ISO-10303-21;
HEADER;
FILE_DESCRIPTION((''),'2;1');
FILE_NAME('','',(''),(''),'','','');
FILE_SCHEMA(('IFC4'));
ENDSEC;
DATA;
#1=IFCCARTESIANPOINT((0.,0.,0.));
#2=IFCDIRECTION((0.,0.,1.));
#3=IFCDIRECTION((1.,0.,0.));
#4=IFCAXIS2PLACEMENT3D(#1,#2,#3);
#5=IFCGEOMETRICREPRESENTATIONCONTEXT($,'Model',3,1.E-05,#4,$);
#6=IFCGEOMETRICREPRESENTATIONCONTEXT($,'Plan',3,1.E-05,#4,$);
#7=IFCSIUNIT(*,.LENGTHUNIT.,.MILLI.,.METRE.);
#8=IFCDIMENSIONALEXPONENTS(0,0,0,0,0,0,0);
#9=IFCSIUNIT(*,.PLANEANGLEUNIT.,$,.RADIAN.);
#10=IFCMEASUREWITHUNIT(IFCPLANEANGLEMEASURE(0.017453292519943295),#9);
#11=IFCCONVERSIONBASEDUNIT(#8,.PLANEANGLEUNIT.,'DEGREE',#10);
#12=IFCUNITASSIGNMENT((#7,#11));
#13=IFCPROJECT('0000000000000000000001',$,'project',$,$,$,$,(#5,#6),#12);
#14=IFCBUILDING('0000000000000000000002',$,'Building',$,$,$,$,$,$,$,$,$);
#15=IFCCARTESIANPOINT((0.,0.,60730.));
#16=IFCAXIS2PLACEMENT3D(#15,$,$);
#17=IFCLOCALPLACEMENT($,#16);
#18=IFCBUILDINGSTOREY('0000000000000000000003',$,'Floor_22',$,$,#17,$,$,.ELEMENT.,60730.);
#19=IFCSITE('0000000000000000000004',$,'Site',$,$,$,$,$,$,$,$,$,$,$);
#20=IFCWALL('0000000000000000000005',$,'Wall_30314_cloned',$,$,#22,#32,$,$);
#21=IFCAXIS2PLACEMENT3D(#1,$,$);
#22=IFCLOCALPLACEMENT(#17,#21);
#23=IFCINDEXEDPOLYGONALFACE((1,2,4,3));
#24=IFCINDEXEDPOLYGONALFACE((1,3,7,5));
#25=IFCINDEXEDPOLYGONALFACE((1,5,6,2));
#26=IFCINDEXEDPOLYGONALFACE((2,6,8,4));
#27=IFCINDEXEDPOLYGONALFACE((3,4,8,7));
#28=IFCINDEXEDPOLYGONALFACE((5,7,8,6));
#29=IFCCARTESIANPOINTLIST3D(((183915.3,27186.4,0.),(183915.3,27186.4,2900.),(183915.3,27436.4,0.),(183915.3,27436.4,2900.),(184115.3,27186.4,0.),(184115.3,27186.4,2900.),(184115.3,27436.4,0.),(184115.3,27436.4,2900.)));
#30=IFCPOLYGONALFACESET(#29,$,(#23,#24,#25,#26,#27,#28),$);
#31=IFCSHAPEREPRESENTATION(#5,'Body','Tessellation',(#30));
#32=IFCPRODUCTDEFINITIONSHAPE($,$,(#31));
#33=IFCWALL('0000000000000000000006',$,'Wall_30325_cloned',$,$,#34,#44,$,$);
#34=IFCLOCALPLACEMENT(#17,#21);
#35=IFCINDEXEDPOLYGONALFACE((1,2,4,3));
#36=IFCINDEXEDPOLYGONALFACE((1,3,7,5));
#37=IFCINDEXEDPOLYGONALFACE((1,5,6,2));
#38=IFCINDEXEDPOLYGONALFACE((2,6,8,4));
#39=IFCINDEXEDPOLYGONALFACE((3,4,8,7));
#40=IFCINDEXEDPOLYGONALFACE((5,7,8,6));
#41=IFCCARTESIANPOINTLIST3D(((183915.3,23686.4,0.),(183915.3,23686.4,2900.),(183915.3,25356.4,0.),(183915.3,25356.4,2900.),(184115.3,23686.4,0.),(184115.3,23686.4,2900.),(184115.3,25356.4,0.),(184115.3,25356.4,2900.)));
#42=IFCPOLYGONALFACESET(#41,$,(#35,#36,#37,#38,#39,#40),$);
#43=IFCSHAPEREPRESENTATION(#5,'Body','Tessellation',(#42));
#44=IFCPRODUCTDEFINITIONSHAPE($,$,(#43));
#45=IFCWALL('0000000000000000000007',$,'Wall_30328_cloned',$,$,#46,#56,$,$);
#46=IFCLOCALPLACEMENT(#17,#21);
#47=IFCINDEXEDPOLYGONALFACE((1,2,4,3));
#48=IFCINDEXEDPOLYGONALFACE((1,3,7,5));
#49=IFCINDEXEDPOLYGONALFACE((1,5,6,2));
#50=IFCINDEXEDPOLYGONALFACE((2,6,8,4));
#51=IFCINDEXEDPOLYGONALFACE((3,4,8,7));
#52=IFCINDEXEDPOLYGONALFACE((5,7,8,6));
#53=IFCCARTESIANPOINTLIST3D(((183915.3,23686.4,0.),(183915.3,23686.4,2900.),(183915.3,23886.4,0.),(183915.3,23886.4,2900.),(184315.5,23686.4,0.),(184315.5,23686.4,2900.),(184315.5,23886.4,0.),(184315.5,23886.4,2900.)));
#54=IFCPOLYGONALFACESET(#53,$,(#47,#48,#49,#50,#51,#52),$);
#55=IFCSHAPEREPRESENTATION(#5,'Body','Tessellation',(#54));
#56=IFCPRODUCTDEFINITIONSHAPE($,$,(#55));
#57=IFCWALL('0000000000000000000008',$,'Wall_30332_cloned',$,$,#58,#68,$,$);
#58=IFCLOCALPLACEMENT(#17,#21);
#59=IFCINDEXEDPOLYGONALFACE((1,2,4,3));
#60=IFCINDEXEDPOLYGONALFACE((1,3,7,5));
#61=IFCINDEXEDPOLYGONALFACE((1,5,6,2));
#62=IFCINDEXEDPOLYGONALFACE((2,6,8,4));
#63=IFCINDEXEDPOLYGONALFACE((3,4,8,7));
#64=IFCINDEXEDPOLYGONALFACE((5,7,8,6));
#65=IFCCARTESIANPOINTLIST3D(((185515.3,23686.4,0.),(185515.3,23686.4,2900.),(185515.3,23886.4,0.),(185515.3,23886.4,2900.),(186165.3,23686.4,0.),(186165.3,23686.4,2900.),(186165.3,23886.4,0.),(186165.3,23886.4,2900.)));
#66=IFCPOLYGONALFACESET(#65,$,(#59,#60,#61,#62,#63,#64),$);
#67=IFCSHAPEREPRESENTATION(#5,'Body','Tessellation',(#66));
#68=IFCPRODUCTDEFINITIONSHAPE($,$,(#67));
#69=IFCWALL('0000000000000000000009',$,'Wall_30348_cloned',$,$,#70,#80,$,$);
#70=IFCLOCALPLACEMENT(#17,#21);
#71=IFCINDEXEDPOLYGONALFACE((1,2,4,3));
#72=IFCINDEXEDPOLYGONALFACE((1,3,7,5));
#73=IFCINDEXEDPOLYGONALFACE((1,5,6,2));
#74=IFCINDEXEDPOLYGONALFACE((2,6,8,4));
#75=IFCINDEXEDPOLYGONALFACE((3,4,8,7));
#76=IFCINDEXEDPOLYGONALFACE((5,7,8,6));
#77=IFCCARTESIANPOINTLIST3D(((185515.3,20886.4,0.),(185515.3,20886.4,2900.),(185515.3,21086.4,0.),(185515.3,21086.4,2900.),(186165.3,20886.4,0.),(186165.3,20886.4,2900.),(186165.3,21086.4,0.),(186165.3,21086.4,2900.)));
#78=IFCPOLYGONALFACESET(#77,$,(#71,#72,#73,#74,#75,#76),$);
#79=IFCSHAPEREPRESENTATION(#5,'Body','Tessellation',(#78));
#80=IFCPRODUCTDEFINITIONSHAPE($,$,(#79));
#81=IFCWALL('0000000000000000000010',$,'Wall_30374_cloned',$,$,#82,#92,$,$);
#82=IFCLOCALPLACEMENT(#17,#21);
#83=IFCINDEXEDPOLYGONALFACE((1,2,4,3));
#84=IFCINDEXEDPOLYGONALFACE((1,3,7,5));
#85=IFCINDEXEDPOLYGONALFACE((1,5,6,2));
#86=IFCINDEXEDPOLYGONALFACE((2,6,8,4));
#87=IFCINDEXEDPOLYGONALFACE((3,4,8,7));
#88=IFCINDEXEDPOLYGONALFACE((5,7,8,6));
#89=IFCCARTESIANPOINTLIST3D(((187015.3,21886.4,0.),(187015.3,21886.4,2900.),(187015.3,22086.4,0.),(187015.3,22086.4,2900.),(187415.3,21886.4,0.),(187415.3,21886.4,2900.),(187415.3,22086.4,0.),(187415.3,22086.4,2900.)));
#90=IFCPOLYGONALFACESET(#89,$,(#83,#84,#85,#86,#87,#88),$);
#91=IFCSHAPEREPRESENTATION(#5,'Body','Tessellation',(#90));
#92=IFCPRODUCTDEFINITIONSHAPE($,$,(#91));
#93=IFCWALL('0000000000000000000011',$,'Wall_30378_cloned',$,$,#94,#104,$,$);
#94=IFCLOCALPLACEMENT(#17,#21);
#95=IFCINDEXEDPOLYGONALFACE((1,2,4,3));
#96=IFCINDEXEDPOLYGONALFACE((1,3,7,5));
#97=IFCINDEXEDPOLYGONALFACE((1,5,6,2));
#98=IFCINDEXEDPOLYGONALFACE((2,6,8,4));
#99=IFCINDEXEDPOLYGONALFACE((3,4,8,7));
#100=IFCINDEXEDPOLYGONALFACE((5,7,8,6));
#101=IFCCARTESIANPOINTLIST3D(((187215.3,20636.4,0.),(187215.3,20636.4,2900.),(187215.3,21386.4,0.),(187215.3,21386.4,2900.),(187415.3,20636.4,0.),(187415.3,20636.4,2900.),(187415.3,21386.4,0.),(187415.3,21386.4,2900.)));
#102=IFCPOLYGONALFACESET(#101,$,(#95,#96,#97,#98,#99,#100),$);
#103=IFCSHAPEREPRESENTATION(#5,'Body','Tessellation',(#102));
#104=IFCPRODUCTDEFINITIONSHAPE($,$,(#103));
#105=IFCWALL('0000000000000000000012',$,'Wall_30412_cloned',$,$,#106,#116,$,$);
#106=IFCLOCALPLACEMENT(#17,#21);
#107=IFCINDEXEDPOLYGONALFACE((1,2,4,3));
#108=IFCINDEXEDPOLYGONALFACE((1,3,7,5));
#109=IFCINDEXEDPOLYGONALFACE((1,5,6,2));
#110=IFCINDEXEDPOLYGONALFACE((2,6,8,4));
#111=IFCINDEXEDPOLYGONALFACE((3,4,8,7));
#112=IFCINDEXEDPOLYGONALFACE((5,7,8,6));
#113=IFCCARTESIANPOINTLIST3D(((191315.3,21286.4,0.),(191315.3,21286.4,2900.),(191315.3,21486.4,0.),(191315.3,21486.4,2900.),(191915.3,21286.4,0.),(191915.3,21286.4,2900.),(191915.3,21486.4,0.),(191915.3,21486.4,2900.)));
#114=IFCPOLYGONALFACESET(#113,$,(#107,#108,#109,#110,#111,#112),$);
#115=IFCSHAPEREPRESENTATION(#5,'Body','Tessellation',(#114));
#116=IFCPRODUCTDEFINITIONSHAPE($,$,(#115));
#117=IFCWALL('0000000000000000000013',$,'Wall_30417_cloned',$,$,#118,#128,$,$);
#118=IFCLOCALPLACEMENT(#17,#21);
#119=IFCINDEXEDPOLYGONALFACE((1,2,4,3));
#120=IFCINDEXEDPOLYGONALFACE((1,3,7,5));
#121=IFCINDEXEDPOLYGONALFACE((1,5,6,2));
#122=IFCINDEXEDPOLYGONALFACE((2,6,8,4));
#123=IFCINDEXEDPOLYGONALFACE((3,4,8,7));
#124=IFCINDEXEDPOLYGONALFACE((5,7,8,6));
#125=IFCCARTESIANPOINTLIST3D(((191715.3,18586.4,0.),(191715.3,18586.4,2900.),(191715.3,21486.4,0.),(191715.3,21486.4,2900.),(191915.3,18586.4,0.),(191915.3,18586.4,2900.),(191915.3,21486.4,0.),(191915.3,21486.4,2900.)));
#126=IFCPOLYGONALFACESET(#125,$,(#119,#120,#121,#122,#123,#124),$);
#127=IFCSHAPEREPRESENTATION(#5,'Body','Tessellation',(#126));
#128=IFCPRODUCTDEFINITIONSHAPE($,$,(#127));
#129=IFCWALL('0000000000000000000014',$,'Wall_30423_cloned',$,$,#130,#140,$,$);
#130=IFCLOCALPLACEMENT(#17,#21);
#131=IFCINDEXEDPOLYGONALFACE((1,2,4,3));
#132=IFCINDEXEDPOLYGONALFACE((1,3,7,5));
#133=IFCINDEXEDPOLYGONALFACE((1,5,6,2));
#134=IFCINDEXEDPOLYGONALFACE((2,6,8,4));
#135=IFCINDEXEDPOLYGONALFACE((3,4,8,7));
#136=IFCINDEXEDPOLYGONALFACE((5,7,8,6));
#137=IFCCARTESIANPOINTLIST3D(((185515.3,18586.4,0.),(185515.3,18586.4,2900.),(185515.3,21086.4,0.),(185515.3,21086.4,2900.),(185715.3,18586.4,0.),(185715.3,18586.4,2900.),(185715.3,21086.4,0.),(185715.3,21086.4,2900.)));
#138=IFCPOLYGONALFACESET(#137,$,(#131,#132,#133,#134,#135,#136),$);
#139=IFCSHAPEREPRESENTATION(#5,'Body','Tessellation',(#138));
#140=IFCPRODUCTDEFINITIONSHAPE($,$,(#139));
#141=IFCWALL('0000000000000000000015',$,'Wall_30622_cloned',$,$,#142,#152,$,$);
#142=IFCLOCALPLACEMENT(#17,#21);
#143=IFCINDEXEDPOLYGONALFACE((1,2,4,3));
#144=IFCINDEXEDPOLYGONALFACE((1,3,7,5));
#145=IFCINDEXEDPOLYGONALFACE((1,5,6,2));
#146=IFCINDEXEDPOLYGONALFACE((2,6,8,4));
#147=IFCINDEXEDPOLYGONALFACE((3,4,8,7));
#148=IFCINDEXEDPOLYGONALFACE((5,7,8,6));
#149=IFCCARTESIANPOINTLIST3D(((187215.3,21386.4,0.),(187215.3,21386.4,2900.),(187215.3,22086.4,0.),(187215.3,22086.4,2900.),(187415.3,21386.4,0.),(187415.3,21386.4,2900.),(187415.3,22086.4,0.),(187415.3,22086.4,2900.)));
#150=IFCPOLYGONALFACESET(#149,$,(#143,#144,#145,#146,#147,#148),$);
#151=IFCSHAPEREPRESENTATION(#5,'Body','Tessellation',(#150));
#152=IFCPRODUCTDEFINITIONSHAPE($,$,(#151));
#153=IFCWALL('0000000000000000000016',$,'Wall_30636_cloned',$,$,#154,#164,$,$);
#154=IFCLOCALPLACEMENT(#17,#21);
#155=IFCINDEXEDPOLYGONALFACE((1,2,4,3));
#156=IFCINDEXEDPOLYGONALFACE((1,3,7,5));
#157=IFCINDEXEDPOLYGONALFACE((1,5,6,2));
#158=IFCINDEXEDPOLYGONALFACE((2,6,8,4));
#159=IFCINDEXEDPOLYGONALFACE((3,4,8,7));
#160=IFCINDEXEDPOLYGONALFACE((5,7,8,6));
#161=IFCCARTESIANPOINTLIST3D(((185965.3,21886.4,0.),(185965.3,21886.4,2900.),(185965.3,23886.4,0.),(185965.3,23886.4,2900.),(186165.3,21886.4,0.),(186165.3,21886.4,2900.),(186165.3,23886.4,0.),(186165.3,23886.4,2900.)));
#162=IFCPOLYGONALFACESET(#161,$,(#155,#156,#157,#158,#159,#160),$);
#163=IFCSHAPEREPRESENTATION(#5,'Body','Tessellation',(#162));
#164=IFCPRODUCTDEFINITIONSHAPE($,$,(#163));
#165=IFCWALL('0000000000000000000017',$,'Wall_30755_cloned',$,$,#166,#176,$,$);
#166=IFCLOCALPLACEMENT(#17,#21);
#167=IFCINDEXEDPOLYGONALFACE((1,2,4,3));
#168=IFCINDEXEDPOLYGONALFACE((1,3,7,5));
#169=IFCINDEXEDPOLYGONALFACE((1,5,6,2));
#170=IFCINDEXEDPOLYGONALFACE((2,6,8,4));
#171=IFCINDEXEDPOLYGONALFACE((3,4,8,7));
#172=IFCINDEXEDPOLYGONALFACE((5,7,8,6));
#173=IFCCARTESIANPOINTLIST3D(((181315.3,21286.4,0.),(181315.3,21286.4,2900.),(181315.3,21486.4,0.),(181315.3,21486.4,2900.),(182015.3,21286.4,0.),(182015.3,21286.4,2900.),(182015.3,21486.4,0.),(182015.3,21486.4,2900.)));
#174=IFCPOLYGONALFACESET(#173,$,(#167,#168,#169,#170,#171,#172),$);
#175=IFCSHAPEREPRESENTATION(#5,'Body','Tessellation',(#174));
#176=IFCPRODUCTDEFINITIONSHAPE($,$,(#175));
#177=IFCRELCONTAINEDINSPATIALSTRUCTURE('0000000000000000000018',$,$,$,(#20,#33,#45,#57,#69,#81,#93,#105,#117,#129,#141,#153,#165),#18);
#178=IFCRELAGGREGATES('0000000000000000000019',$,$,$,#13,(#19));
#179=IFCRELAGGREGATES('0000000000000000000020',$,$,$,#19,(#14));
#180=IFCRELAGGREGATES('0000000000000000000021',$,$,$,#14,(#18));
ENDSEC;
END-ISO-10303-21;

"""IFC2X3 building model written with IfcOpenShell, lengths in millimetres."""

from ifc_helpers import new_model, entity, si_unit, converted_unit, frame, origin_with_axes, origin_2d, place, context, project, spatial, rectangle, extrude, source, transform, mapped, element, save


model = new_model("IFC2X3")

# Units and contexts
model_context = context("Model", 3, precision=1e-05, world=origin_with_axes())
plan_context = context("Plan", 3, precision=1e-05, world=origin_with_axes())
ifc_project = project(units=[si_unit("LENGTHUNIT", "METRE", prefix="MILLI"), converted_unit("PLANEANGLEUNIT", "DEGREE", entity("IfcPlaneAngleMeasure", 0.017453292519943295), si_unit("PLANEANGLEUNIT", "RADIAN"), dimensions=[0, 0, 0, 0, 0, 0, 0])], contexts=[model_context, plan_context])

# Site, building, storey
site = spatial("IfcSite", under=ifc_project, Name="Site")
building = spatial("IfcBuilding", under=site, Name="Building")
storey_placement = place(None, frame((0.0, 0.0, 60730.0)))
storey = spatial("IfcBuildingStorey", under=building, at=storey_placement, Name="Floor_22", CompositionType="ELEMENT", Elevation=60730.0)

# Walls
shared_shape_1 = source(origin_with_axes(), model_context, "Body", "SweptSolid", [
    extrude(rectangle(XDim=250.0, YDim=200.0, at=origin_2d()), origin_with_axes(), (0.0, 0.0, 1.0), 2900.0),
])
wall_1_placement = place(storey_placement, frame((184015.3, 27311.4, 0.0), z_axis=(0.0, 0.0, 1.0), x_axis=(0.0, 249.999994, 0.0)))
element("IfcWall", 1, at=wall_1_placement, inside=storey, Name="Wall_30314_cloned", context=model_context, shape_type="MappedRepresentation", body=[
    mapped(shared_shape_1, transform((0.0, 0.0, 0.0), x_axis=(1.0, 0.0, 0.0), y_axis=(0.0, 1.0, 0.0), z_axis=(0.0, 0.0, 1.0), scale=1.0)),
])
shared_shape_2 = source(origin_with_axes(), model_context, "Body", "SweptSolid", [
    extrude(rectangle(XDim=1670.0, YDim=200.0, at=origin_2d()), origin_with_axes(), (0.0, 0.0, 1.0), 2900.0),
])
wall_2_placement = place(storey_placement, frame((184015.3, 24521.4, 0.0), z_axis=(0.0, 0.0, 1.0), x_axis=(0.0, 1669.999996, 0.0)))
element("IfcWall", 2, at=wall_2_placement, inside=storey, Name="Wall_30325_cloned", context=model_context, shape_type="MappedRepresentation", body=[
    mapped(shared_shape_2, transform((0.0, 0.0, 0.0), x_axis=(1.0, 0.0, 0.0), y_axis=(0.0, 1.0, 0.0), z_axis=(0.0, 0.0, 1.0), scale=1.0)),
])
shared_shape_3 = source(origin_with_axes(), model_context, "Body", "SweptSolid", [
    extrude(rectangle(XDim=400.1, YDim=200.0, at=origin_2d()), origin_with_axes(), (0.0, 0.0, 1.0), 2900.0),
])
wall_3_placement = place(storey_placement, frame((184115.4, 23786.4, 0.0), z_axis=(0.0, 0.0, 1.0), x_axis=(400.146534, -0.000012, 0.0)))
element("IfcWall", 3, at=wall_3_placement, inside=storey, Name="Wall_30328_cloned", context=model_context, shape_type="MappedRepresentation", body=[
    mapped(shared_shape_3, transform((0.0, 0.0, 0.0), x_axis=(1.0, 0.0, 0.0), y_axis=(0.0, 1.0, 0.0), z_axis=(0.0, 0.0, 1.0), scale=1.0)),
])
shared_shape_4 = source(origin_with_axes(), model_context, "Body", "SweptSolid", [
    extrude(rectangle(XDim=650.0, YDim=200.0, at=origin_2d()), origin_with_axes(), (0.0, 0.0, 1.0), 2900.0),
])
wall_4_placement = place(storey_placement, frame((185840.3, 23786.4, 0.0), z_axis=(0.0, 0.0, 1.0), x_axis=(650.0, 0.0, 0.0)))
element("IfcWall", 4, at=wall_4_placement, inside=storey, Name="Wall_30332_cloned", context=model_context, shape_type="MappedRepresentation", body=[
    mapped(shared_shape_4, transform((0.0, 0.0, 0.0), x_axis=(1.0, 0.0, 0.0), y_axis=(0.0, 1.0, 0.0), z_axis=(0.0, 0.0, 1.0), scale=1.0)),
])
shared_shape_5 = source(origin_with_axes(), model_context, "Body", "SweptSolid", [
    extrude(rectangle(XDim=650.0, YDim=200.0, at=origin_2d()), origin_with_axes(), (0.0, 0.0, 1.0), 2900.0),
])
wall_5_placement = place(storey_placement, frame((185840.3, 20986.4, 0.0), z_axis=(0.0, 0.0, 1.0), x_axis=(650.0, 0.0, 0.0)))
element("IfcWall", 5, at=wall_5_placement, inside=storey, Name="Wall_30348_cloned", context=model_context, shape_type="MappedRepresentation", body=[
    mapped(shared_shape_5, transform((0.0, 0.0, 0.0), x_axis=(1.0, 0.0, 0.0), y_axis=(0.0, 1.0, 0.0), z_axis=(0.0, 0.0, 1.0), scale=1.0)),
])
shared_shape_6 = source(origin_with_axes(), model_context, "Body", "SweptSolid", [
    extrude(rectangle(XDim=400.0, YDim=200.0, at=origin_2d()), origin_with_axes(), (0.0, 0.0, 1.0), 2900.0),
])
wall_6_placement = place(storey_placement, frame((187215.3, 21986.4, 0.0), z_axis=(0.0, 0.0, 1.0), x_axis=(400.0, 0.0, 0.0)))
element("IfcWall", 6, at=wall_6_placement, inside=storey, Name="Wall_30374_cloned", context=model_context, shape_type="MappedRepresentation", body=[
    mapped(shared_shape_6, transform((0.0, 0.0, 0.0), x_axis=(1.0, 0.0, 0.0), y_axis=(0.0, 1.0, 0.0), z_axis=(0.0, 0.0, 1.0), scale=1.0)),
])
shared_shape_7 = source(origin_with_axes(), model_context, "Body", "SweptSolid", [
    extrude(rectangle(XDim=750.0, YDim=200.0, at=origin_2d()), origin_with_axes(), (0.0, 0.0, 1.0), 2900.0),
])
wall_7_placement = place(storey_placement, frame((187315.3, 21011.4, 0.0), z_axis=(0.0, 0.0, 1.0), x_axis=(0.0, 750.0, 0.0)))
element("IfcWall", 7, at=wall_7_placement, inside=storey, Name="Wall_30378_cloned", context=model_context, shape_type="MappedRepresentation", body=[
    mapped(shared_shape_7, transform((0.0, 0.0, 0.0), x_axis=(1.0, 0.0, 0.0), y_axis=(0.0, 1.0, 0.0), z_axis=(0.0, 0.0, 1.0), scale=1.0)),
])
shared_shape_8 = source(origin_with_axes(), model_context, "Body", "SweptSolid", [
    extrude(rectangle(XDim=600.0, YDim=200.0, at=origin_2d()), origin_with_axes(), (0.0, 0.0, 1.0), 2900.0),
])
wall_8_placement = place(storey_placement, frame((191615.3, 21386.4, 0.0), z_axis=(0.0, 0.0, 1.0), x_axis=(600.0, 0.0, 0.0)))
element("IfcWall", 8, at=wall_8_placement, inside=storey, Name="Wall_30412_cloned", context=model_context, shape_type="MappedRepresentation", body=[
    mapped(shared_shape_8, transform((0.0, 0.0, 0.0), x_axis=(1.0, 0.0, 0.0), y_axis=(0.0, 1.0, 0.0), z_axis=(0.0, 0.0, 1.0), scale=1.0)),
])
shared_shape_9 = source(origin_with_axes(), model_context, "Body", "SweptSolid", [
    extrude(rectangle(XDim=2900.0, YDim=200.0, at=origin_2d()), origin_with_axes(), (0.0, 0.0, 1.0), 2900.0),
])
wall_9_placement = place(storey_placement, frame((191815.3, 20036.4, 0.0), z_axis=(0.0, 0.0, 1.0), x_axis=(0.0, 2900.0, 0.0)))
element("IfcWall", 9, at=wall_9_placement, inside=storey, Name="Wall_30417_cloned", context=model_context, shape_type="MappedRepresentation", body=[
    mapped(shared_shape_9, transform((0.0, 0.0, 0.0), x_axis=(1.0, 0.0, 0.0), y_axis=(0.0, 1.0, 0.0), z_axis=(0.0, 0.0, 1.0), scale=1.0)),
])
shared_shape_10 = source(origin_with_axes(), model_context, "Body", "SweptSolid", [
    extrude(rectangle(XDim=2500.0, YDim=200.0, at=origin_2d()), origin_with_axes(), (0.0, 0.0, 1.0), 2900.0),
])
wall_10_placement = place(storey_placement, frame((185615.3, 19836.4, 0.0), z_axis=(0.0, 0.0, 1.0), x_axis=(0.0, 2500.0, 0.0)))
element("IfcWall", 10, at=wall_10_placement, inside=storey, Name="Wall_30423_cloned", context=model_context, shape_type="MappedRepresentation", body=[
    mapped(shared_shape_10, transform((0.0, 0.0, 0.0), x_axis=(1.0, 0.0, 0.0), y_axis=(0.0, 1.0, 0.0), z_axis=(0.0, 0.0, 1.0), scale=1.0)),
])
shared_shape_11 = source(origin_with_axes(), model_context, "Body", "SweptSolid", [
    extrude(rectangle(XDim=700.0, YDim=200.0, at=origin_2d()), origin_with_axes(), (0.0, 0.0, 1.0), 2900.0),
])
wall_11_placement = place(storey_placement, frame((187315.3, 21736.4, 0.0), z_axis=(0.0, 0.0, 1.0), x_axis=(0.0, 700.0, 0.0)))
element("IfcWall", 11, at=wall_11_placement, inside=storey, Name="Wall_30622_cloned", context=model_context, shape_type="MappedRepresentation", body=[
    mapped(shared_shape_11, transform((0.0, 0.0, 0.0), x_axis=(1.0, 0.0, 0.0), y_axis=(0.0, 1.0, 0.0), z_axis=(0.0, 0.0, 1.0), scale=1.0)),
])
shared_shape_12 = source(origin_with_axes(), model_context, "Body", "SweptSolid", [
    extrude(rectangle(XDim=2000.0, YDim=200.0, at=origin_2d()), origin_with_axes(), (0.0, 0.0, 1.0), 2900.0),
])
wall_12_placement = place(storey_placement, frame((186065.3, 22886.4, 0.0), z_axis=(0.0, 0.0, 1.0), x_axis=(0.0, 2000.0, 0.0)))
element("IfcWall", 12, at=wall_12_placement, inside=storey, Name="Wall_30636_cloned", context=model_context, shape_type="MappedRepresentation", body=[
    mapped(shared_shape_12, transform((0.0, 0.0, 0.0), x_axis=(1.0, 0.0, 0.0), y_axis=(0.0, 1.0, 0.0), z_axis=(0.0, 0.0, 1.0), scale=1.0)),
])
shared_shape_13 = source(origin_with_axes(), model_context, "Body", "SweptSolid", [
    extrude(rectangle(XDim=700.0, YDim=200.0, at=origin_2d()), origin_with_axes(), (0.0, 0.0, 1.0), 2900.0),
])
wall_13_placement = place(storey_placement, frame((181665.3, 21386.4, 0.0), z_axis=(0.0, 0.0, 1.0), x_axis=(699.999906, 0.0, 0.0)))
element("IfcWall", 13, at=wall_13_placement, inside=storey, Name="Wall_30755_cloned", context=model_context, shape_type="MappedRepresentation", body=[
    mapped(shared_shape_13, transform((0.0, 0.0, 0.0), x_axis=(1.0, 0.0, 0.0), y_axis=(0.0, 1.0, 0.0), z_axis=(0.0, 0.0, 1.0), scale=1.0)),
])

save(model, "model.ifc")
